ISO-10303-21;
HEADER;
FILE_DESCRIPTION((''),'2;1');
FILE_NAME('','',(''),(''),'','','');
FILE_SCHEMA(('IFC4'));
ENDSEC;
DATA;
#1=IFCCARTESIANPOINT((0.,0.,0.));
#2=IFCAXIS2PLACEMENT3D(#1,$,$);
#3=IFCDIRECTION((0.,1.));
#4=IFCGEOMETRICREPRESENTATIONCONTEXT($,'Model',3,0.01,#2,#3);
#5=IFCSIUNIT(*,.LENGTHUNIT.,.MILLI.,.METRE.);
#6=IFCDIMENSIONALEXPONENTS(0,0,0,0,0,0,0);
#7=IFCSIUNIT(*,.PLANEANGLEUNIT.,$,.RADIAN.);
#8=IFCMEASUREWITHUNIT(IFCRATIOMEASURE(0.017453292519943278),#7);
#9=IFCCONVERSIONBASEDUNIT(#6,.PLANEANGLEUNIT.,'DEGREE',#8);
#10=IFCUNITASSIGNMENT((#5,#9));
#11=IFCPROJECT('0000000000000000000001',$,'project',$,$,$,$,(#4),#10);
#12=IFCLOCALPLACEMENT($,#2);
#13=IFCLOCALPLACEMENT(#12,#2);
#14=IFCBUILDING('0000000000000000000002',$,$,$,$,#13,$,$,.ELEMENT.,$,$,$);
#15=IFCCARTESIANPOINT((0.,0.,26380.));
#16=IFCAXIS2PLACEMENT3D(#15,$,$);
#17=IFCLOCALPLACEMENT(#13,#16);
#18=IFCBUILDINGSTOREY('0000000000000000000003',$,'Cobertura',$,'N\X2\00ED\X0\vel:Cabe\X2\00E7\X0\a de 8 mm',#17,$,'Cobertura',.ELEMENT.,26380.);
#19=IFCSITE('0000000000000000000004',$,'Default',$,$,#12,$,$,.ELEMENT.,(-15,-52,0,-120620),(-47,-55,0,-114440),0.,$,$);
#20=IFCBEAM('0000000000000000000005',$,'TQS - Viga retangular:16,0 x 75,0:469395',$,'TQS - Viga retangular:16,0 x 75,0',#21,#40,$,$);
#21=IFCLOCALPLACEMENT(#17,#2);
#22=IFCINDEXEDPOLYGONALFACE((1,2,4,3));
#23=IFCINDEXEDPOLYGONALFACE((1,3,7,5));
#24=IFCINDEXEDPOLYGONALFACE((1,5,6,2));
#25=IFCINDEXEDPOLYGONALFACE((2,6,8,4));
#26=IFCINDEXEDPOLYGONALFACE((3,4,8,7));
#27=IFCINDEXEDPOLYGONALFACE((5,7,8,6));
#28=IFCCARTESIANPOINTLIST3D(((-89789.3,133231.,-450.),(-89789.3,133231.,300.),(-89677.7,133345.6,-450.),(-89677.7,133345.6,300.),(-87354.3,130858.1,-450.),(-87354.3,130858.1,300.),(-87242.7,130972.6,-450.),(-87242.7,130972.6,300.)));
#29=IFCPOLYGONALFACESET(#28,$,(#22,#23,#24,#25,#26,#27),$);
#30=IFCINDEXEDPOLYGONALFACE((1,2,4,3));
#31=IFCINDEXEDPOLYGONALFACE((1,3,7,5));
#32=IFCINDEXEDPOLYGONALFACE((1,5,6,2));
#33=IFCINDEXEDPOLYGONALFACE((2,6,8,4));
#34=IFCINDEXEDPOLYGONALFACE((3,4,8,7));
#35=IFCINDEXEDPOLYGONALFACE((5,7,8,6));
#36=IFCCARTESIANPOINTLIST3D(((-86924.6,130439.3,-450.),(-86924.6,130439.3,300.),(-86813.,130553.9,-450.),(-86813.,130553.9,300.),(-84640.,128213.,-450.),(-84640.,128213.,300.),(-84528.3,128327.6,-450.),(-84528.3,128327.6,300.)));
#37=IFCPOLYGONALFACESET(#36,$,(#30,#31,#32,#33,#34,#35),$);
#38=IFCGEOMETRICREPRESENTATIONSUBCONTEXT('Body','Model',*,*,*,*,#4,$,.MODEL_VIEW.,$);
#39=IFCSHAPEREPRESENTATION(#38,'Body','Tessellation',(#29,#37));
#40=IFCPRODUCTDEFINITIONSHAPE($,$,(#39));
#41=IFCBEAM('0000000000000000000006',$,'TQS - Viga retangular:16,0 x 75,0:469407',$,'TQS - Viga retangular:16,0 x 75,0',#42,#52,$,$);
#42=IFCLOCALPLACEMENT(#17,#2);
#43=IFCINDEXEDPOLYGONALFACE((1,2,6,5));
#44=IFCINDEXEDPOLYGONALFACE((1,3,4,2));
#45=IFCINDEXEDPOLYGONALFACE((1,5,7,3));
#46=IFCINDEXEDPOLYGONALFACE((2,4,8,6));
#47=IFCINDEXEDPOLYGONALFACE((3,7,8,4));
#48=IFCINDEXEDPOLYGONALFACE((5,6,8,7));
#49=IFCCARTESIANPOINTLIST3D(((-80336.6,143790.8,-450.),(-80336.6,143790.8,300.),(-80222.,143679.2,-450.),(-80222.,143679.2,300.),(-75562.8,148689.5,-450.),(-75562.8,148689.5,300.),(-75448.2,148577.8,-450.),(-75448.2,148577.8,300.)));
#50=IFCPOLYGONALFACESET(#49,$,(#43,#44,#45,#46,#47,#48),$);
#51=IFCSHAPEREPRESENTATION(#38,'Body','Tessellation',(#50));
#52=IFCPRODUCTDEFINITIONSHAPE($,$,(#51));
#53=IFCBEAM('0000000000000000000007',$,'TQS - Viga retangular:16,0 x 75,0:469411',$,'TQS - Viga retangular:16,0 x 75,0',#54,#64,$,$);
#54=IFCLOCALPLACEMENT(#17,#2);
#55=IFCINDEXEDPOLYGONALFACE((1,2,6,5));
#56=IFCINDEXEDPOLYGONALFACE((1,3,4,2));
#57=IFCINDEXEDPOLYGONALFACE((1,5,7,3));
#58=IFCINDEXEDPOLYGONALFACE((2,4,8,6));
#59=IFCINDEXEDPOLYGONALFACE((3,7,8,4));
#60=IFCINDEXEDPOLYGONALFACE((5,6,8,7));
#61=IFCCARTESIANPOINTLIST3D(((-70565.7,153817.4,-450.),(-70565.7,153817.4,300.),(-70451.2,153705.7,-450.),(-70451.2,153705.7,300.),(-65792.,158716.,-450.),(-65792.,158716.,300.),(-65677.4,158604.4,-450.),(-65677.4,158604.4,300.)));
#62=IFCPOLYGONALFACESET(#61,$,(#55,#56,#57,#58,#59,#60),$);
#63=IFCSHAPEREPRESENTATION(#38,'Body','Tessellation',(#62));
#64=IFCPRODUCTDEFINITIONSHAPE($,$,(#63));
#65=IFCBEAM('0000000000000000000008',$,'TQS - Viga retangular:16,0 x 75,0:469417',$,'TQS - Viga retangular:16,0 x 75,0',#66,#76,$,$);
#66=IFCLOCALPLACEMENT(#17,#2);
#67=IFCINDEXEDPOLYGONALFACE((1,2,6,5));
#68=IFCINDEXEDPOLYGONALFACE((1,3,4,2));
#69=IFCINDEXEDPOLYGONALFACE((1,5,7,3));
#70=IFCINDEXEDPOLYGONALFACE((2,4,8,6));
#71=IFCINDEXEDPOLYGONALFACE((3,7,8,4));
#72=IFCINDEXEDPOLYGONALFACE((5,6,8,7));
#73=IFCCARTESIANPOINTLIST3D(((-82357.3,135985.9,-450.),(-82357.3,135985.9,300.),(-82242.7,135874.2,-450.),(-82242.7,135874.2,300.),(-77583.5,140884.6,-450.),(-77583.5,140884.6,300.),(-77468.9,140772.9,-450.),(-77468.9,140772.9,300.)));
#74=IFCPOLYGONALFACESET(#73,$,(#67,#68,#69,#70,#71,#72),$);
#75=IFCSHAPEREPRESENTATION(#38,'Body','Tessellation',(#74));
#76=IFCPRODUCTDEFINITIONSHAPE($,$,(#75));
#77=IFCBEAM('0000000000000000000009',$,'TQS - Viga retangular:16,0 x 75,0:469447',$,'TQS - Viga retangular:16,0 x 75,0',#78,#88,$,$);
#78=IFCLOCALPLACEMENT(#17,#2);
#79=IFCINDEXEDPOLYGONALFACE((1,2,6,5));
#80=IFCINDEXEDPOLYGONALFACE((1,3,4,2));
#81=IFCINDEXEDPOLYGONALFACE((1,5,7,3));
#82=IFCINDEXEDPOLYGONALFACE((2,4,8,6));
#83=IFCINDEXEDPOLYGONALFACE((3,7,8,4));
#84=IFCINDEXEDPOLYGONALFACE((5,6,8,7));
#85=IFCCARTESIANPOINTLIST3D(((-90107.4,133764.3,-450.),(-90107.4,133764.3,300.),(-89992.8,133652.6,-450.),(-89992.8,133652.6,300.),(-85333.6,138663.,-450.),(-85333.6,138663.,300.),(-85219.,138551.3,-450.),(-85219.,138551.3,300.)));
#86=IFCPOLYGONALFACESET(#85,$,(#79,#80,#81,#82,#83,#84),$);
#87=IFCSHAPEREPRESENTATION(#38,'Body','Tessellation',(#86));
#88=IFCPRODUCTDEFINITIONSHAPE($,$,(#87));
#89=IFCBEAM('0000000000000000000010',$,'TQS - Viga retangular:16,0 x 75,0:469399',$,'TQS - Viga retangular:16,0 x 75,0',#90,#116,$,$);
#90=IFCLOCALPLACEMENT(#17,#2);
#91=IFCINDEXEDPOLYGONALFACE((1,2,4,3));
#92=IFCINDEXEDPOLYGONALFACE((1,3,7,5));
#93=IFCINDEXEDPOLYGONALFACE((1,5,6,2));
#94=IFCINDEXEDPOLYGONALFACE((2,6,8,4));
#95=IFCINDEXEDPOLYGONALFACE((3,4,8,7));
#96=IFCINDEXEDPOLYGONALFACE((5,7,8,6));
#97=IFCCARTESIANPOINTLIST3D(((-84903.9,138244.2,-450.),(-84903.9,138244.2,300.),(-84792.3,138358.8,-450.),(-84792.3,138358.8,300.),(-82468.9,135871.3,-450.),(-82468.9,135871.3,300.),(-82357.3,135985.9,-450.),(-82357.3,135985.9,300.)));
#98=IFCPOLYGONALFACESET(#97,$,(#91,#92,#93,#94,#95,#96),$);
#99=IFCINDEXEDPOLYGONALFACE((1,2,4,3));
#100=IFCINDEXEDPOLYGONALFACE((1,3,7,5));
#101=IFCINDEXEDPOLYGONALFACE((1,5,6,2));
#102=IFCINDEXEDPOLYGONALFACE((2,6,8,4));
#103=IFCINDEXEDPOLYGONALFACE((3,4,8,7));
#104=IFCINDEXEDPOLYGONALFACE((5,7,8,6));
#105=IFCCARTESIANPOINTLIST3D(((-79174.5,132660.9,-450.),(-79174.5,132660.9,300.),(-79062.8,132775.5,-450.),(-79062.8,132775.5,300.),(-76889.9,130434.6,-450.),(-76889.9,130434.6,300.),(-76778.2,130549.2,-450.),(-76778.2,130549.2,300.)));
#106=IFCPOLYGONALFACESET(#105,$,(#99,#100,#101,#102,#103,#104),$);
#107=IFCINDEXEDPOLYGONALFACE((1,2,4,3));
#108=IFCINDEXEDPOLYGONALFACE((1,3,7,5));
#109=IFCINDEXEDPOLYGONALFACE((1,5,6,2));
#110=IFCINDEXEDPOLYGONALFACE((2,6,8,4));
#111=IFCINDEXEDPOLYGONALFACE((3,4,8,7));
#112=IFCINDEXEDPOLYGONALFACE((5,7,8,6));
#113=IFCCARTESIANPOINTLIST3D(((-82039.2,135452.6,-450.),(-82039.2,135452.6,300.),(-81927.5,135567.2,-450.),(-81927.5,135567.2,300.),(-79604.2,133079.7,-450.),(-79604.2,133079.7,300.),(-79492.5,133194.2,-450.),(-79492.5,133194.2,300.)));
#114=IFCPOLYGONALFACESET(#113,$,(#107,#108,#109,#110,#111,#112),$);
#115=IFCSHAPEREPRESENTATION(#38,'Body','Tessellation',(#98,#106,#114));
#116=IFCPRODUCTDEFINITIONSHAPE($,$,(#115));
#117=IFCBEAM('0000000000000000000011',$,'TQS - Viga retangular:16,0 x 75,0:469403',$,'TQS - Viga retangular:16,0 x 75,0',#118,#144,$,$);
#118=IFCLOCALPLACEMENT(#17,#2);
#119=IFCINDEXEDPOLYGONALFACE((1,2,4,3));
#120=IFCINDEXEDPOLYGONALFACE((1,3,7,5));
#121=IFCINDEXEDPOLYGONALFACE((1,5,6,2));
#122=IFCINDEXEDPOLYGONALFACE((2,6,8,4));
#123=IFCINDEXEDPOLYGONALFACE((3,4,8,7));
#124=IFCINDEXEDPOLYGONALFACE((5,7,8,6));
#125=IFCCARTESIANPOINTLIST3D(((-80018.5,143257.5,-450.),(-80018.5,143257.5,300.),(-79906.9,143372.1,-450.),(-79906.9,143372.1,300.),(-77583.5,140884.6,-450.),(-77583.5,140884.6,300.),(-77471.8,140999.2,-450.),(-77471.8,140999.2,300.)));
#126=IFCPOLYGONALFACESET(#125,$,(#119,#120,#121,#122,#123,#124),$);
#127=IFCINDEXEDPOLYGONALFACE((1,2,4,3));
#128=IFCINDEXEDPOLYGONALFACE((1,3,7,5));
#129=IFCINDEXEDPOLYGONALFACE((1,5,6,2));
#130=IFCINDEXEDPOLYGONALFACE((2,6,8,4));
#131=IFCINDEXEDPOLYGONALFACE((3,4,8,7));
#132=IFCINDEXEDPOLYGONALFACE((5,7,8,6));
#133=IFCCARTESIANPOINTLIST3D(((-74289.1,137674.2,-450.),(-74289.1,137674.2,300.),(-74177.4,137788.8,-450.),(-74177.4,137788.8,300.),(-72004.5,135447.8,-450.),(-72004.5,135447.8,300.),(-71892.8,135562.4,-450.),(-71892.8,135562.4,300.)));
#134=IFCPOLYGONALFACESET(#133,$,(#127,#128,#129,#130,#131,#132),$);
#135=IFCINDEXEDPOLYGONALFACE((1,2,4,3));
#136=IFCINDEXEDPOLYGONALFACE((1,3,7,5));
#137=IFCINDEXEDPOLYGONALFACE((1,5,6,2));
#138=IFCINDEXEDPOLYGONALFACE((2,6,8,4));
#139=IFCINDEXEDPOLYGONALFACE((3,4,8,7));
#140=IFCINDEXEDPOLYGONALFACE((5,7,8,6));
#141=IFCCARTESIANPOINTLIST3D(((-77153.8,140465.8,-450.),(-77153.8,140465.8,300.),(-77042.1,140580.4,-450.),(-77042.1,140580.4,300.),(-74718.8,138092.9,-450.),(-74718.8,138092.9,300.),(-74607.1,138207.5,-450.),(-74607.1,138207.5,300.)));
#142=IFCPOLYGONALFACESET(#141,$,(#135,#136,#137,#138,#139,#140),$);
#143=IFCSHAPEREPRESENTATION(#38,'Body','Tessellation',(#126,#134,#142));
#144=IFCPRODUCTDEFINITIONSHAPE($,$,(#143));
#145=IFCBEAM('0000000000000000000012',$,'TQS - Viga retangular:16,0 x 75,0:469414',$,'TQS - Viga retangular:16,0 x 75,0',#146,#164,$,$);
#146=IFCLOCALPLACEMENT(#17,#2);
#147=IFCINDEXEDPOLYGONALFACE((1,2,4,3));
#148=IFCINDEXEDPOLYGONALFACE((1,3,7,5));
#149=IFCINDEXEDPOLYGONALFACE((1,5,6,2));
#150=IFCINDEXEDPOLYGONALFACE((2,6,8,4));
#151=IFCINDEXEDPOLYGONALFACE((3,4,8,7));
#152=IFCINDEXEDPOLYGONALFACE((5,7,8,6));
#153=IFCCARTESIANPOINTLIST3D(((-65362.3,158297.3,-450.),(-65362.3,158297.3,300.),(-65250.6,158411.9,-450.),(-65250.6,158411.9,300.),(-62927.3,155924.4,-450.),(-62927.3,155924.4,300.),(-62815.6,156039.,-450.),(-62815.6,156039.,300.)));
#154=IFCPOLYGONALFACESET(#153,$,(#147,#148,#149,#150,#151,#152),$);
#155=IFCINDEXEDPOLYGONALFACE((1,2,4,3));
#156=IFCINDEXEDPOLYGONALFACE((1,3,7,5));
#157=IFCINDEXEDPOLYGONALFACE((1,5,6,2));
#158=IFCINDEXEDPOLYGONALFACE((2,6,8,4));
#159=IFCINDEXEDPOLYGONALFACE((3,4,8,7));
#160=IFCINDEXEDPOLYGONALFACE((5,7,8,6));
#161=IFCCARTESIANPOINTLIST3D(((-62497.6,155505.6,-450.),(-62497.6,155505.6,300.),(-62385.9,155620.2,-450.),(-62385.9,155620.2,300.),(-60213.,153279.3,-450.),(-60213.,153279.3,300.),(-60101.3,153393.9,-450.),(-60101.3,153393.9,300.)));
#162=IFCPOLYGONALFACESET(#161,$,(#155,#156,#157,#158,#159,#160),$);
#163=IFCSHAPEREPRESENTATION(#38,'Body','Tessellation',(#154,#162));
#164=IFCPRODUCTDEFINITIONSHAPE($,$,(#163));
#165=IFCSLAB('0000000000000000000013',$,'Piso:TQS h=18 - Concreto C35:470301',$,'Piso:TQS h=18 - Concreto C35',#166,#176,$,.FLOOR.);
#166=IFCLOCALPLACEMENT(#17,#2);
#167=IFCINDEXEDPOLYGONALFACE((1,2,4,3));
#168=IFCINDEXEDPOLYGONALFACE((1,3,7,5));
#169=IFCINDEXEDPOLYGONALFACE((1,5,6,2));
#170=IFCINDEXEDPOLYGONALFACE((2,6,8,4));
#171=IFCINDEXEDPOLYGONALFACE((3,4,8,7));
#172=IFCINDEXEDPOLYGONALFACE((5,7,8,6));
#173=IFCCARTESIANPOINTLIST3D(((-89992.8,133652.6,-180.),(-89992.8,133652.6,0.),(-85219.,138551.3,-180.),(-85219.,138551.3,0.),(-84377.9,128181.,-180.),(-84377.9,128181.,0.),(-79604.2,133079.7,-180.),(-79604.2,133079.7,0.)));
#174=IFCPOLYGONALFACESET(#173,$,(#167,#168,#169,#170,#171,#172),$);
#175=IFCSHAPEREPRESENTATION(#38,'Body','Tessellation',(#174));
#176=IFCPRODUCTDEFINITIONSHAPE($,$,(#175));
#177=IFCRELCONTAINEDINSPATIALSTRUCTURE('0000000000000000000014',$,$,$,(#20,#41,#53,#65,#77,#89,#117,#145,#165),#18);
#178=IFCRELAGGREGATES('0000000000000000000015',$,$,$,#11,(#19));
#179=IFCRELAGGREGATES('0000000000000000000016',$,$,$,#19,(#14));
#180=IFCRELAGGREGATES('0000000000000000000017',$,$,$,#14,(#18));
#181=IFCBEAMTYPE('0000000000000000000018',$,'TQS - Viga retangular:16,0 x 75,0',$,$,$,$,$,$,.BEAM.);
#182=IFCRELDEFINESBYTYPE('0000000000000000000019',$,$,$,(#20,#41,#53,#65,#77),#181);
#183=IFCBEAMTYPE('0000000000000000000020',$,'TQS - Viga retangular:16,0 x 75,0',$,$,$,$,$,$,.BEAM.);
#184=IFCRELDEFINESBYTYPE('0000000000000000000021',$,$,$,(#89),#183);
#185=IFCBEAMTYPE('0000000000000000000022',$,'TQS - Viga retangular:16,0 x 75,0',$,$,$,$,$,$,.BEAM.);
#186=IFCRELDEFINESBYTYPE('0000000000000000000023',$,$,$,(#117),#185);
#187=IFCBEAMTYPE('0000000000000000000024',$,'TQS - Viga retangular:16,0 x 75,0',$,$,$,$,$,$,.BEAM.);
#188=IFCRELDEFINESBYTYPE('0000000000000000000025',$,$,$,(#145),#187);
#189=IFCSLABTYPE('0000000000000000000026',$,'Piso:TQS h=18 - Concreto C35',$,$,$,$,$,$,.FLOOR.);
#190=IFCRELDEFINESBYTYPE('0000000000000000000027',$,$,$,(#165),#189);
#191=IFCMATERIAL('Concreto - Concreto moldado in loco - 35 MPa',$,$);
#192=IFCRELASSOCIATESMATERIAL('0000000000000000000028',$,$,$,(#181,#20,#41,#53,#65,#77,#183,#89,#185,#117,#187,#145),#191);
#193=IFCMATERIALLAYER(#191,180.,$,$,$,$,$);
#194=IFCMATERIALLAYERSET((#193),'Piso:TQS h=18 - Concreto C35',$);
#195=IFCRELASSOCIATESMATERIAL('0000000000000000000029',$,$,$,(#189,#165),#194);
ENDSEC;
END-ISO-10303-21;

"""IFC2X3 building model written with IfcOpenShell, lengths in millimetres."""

from ifc_helpers import new_model, entity, si_unit, converted_unit, direction, frame, frame_2d, origin, place, context, subcontext, project, spatial, rectangle, extrude, source, transform, mapped, material, layer, layer_set, layer_usage, type_object, type_shapes, element, save


model = new_model("IFC2X3")

# Units and contexts
model_context = context("Model", 3, precision=0.01, world=origin(), true_north=direction((0.0, 1.0)))
body_context = subcontext(model_context, "Body", "Model", "MODEL_VIEW")
ifc_project = project(units=[si_unit("LENGTHUNIT", "METRE", prefix="MILLI"), converted_unit("PLANEANGLEUNIT", "DEGREE", entity("IfcRatioMeasure", 0.017453292519943278), si_unit("PLANEANGLEUNIT", "RADIAN"), dimensions=[0, 0, 0, 0, 0, 0, 0])], contexts=[model_context])

# Site, building, storey
site_placement = place(None, origin())
site = spatial("IfcSite", under=ifc_project, at=site_placement, Name="Default", CompositionType="ELEMENT", RefLatitude=(-15, -52, 0, -120620), RefLongitude=(-47, -55, 0, -114440), RefElevation=0.0)
building_placement = place(site_placement, origin())
building = spatial("IfcBuilding", under=site, at=building_placement, CompositionType="ELEMENT")
storey_placement = place(building_placement, frame((0.0, 0.0, 26380.0)))
storey = spatial("IfcBuildingStorey", under=building, at=storey_placement, Name="Cobertura", ObjectType="Nível:Cabeça de 8 mm", LongName="Cobertura", CompositionType="ELEMENT", Elevation=26380.0)

# Beams
ifc_material = material(Name="Concreto - Concreto moldado in loco - 35 MPa")
beam_type_1 = type_object("IfcBeamType", Name="TQS - Viga retangular:16,0 x 75,0", PredefinedType="BEAM", material=ifc_material)
shared_shape_1 = source(origin(), body_context, "Body", "SweptSolid", [
    extrude(rectangle(XDim=750.0, YDim=160.0, at=frame_2d((0.0, 0.0), x_axis=(1.0, 0.0))), frame((-87298.5, 130915.4, 26305.0), z_axis=(-0.71618, 0.697915, 0.0), x_axis=(0.0, 0.0, 1.0)), (0.0, 0.0, 1.0), 3400.0),
    extrude(rectangle(XDim=750.0, YDim=160.0, at=frame_2d((0.0, 0.0), x_axis=(1.0, 0.0))), frame((-84584.2, 128270.3, 26305.0), z_axis=(-0.71618, 0.697915, 0.0), x_axis=(0.0, 0.0, 1.0)), (0.0, 0.0, 1.0), 3190.0),
])
type_shapes(beam_type_1, [shared_shape_1])
beam_1_placement = place(storey_placement, frame((0.0, 0.0, -26380.0)))
element("IfcBeam", 1, at=beam_1_placement, inside=storey, type_object=beam_type_1, material=ifc_material, Name="TQS - Viga retangular:16,0 x 75,0:469395", ObjectType="TQS - Viga retangular:16,0 x 75,0", context=body_context, shape_type="MappedRepresentation", body=[
    mapped(shared_shape_1, transform((0.0, 0.0, 0.0), scale=1.0)),
])
beam_2_placement = place(storey_placement, frame((-80335.1, 143677.7, 300.0), z_axis=(0.0, 0.0, 1.0), x_axis=(0.697915, 0.71618, 0.0)))
element("IfcBeam", 2, at=beam_2_placement, inside=storey, type_object=beam_type_1, material=ifc_material, Name="TQS - Viga retangular:16,0 x 75,0:469407", ObjectType="TQS - Viga retangular:16,0 x 75,0", context=body_context, shape_type="SweptSolid", body=[
    extrude(rectangle(XDim=750.0, YDim=160.0, at=frame_2d((0.0, 0.0), x_axis=(1.0, 0.0))), frame((80.0, 0.0, -375.0), z_axis=(1.0, 0.0, 0.0), x_axis=(0.0, 0.0, -1.0)), (0.0, 0.0, 1.0), 6840.0),
])
beam_3_placement = place(storey_placement, frame((-70564.3, 153704.2, 300.0), z_axis=(0.0, 0.0, 1.0), x_axis=(0.697915, 0.71618, 0.0)))
element("IfcBeam", 3, at=beam_3_placement, inside=storey, type_object=beam_type_1, material=ifc_material, Name="TQS - Viga retangular:16,0 x 75,0:469411", ObjectType="TQS - Viga retangular:16,0 x 75,0", context=body_context, shape_type="SweptSolid", body=[
    extrude(rectangle(XDim=750.0, YDim=160.0, at=frame_2d((0.0, 0.0), x_axis=(1.0, 0.0))), frame((80.0, 0.0, -375.0), z_axis=(1.0, 0.0, 0.0), x_axis=(0.0, 0.0, -1.0)), (0.0, 0.0, 1.0), 6840.0),
])
beam_4_placement = place(storey_placement, frame((-82355.8, 135872.8, 300.0), z_axis=(0.0, 0.0, 1.0), x_axis=(0.697915, 0.71618, 0.0)))
element("IfcBeam", 4, at=beam_4_placement, inside=storey, type_object=beam_type_1, material=ifc_material, Name="TQS - Viga retangular:16,0 x 75,0:469417", ObjectType="TQS - Viga retangular:16,0 x 75,0", context=body_context, shape_type="SweptSolid", body=[
    extrude(rectangle(XDim=750.0, YDim=160.0, at=frame_2d((0.0, 0.0), x_axis=(1.0, 0.0))), frame((80.0, 0.0, -375.0), z_axis=(1.0, 0.0, 0.0), x_axis=(0.0, 0.0, -1.0)), (0.0, 0.0, 1.0), 6840.0),
])
beam_5_placement = place(storey_placement, frame((-90105.9, 133651.2, 300.0), z_axis=(0.0, 0.0, 1.0), x_axis=(0.697915, 0.71618, 0.0)))
element("IfcBeam", 5, at=beam_5_placement, inside=storey, type_object=beam_type_1, material=ifc_material, Name="TQS - Viga retangular:16,0 x 75,0:469447", ObjectType="TQS - Viga retangular:16,0 x 75,0", context=body_context, shape_type="SweptSolid", body=[
    extrude(rectangle(XDim=750.0, YDim=160.0, at=frame_2d((0.0, 0.0), x_axis=(1.0, 0.0))), frame((80.0, 0.0, -375.0), z_axis=(1.0, 0.0, 0.0), x_axis=(0.0, 0.0, -1.0)), (0.0, 0.0, 1.0), 6840.0),
])
beam_type_2 = type_object("IfcBeamType", Name="TQS - Viga retangular:16,0 x 75,0", PredefinedType="BEAM", material=ifc_material)
shared_shape_2 = source(origin(), body_context, "Body", "SweptSolid", [
    extrude(rectangle(XDim=750.0, YDim=160.0, at=frame_2d((0.0, 0.0), x_axis=(1.0, 0.0))), frame((-82413.1, 135928.6, 26305.0), z_axis=(-0.71618, 0.697915, 0.0), x_axis=(0.0, 0.0, 1.0)), (0.0, 0.0, 1.0), 3400.0),
    extrude(rectangle(XDim=750.0, YDim=160.0, at=frame_2d((0.0, 0.0), x_axis=(1.0, 0.0))), frame((-76834.0, 130491.9, 26305.0), z_axis=(-0.71618, 0.697915, 0.0), x_axis=(0.0, 0.0, 1.0)), (0.0, 0.0, 1.0), 3190.0),
    extrude(rectangle(XDim=750.0, YDim=160.0, at=frame_2d((0.0, 0.0), x_axis=(1.0, 0.0))), frame((-79548.4, 133137.0, 26305.0), z_axis=(-0.71618, 0.697915, 0.0), x_axis=(0.0, 0.0, 1.0)), (0.0, 0.0, 1.0), 3400.0),
])
type_shapes(beam_type_2, [shared_shape_2])
beam_6_placement = place(storey_placement, frame((0.0, 0.0, -26380.0)))
element("IfcBeam", 6, at=beam_6_placement, inside=storey, type_object=beam_type_2, material=ifc_material, Name="TQS - Viga retangular:16,0 x 75,0:469399", ObjectType="TQS - Viga retangular:16,0 x 75,0", context=body_context, shape_type="MappedRepresentation", body=[
    mapped(shared_shape_2, transform((0.0, 0.0, 0.0), scale=1.0)),
])
beam_type_3 = type_object("IfcBeamType", Name="TQS - Viga retangular:16,0 x 75,0", PredefinedType="BEAM", material=ifc_material)
shared_shape_3 = source(origin(), body_context, "Body", "SweptSolid", [
    extrude(rectangle(XDim=750.0, YDim=160.0, at=frame_2d((0.0, 0.0), x_axis=(1.0, 0.0))), frame((-77527.7, 140941.9, 26305.0), z_axis=(-0.71618, 0.697915, 0.0), x_axis=(0.0, 0.0, 1.0)), (0.0, 0.0, 1.0), 3400.0),
    extrude(rectangle(XDim=750.0, YDim=160.0, at=frame_2d((0.0, 0.0), x_axis=(1.0, 0.0))), frame((-71948.6, 135505.1, 26305.0), z_axis=(-0.71618, 0.697915, 0.0), x_axis=(0.0, 0.0, 1.0)), (0.0, 0.0, 1.0), 3190.0),
    extrude(rectangle(XDim=750.0, YDim=160.0, at=frame_2d((0.0, 0.0), x_axis=(1.0, 0.0))), frame((-74663.0, 138150.2, 26305.0), z_axis=(-0.71618, 0.697915, 0.0), x_axis=(0.0, 0.0, 1.0)), (0.0, 0.0, 1.0), 3400.0),
])
type_shapes(beam_type_3, [shared_shape_3])
beam_7_placement = place(storey_placement, frame((0.0, 0.0, -26380.0)))
element("IfcBeam", 7, at=beam_7_placement, inside=storey, type_object=beam_type_3, material=ifc_material, Name="TQS - Viga retangular:16,0 x 75,0:469403", ObjectType="TQS - Viga retangular:16,0 x 75,0", context=body_context, shape_type="MappedRepresentation", body=[
    mapped(shared_shape_3, transform((0.0, 0.0, 0.0), scale=1.0)),
])
beam_type_4 = type_object("IfcBeamType", Name="TQS - Viga retangular:16,0 x 75,0", PredefinedType="BEAM", material=ifc_material)
shared_shape_4 = source(origin(), body_context, "Body", "SweptSolid", [
    extrude(rectangle(XDim=750.0, YDim=160.0, at=frame_2d((0.0, 0.0), x_axis=(1.0, 0.0))), frame((-62871.5, 155981.7, 26305.0), z_axis=(-0.71618, 0.697915, 0.0), x_axis=(0.0, 0.0, 1.0)), (0.0, 0.0, 1.0), 3400.0),
    extrude(rectangle(XDim=750.0, YDim=160.0, at=frame_2d((0.0, 0.0), x_axis=(1.0, 0.0))), frame((-60157.1, 153336.6, 26305.0), z_axis=(-0.71618, 0.697915, 0.0), x_axis=(0.0, 0.0, 1.0)), (0.0, 0.0, 1.0), 3190.0),
])
type_shapes(beam_type_4, [shared_shape_4])
beam_8_placement = place(storey_placement, frame((0.0, 0.0, -26380.0)))
element("IfcBeam", 8, at=beam_8_placement, inside=storey, type_object=beam_type_4, material=ifc_material, Name="TQS - Viga retangular:16,0 x 75,0:469414", ObjectType="TQS - Viga retangular:16,0 x 75,0", context=body_context, shape_type="MappedRepresentation", body=[
    mapped(shared_shape_4, transform((0.0, 0.0, 0.0), scale=1.0)),
])

# Slab
ifc_layer_1 = layer(ifc_material, 180.0)
ifc_layer_set_1 = layer_set([ifc_layer_1], Name="Piso:TQS h=18 - Concreto C35")
ifc_layer_usage_1 = layer_usage(ifc_layer_set_1, "AXIS3", "POSITIVE", 0.0)
slab_type_1 = type_object("IfcSlabType", Name="Piso:TQS h=18 - Concreto C35", PredefinedType="FLOOR", material=ifc_layer_set_1)
slab_1_placement = place(storey_placement, origin())
element("IfcSlab", 9, at=slab_1_placement, inside=storey, type_object=slab_type_1, material=ifc_layer_usage_1, Name="Piso:TQS h=18 - Concreto C35:470301", ObjectType="Piso:TQS h=18 - Concreto C35", PredefinedType="FLOOR", context=body_context, shape_type="SweptSolid", body=[
    extrude(rectangle(XDim=6840.0, YDim=7840.0, at=frame_2d((0.0, 0.0), x_axis=(1.0, 0.0))), frame((-84798.5, 133366.2, 0.0), z_axis=(0.0, 0.0, -1.0), x_axis=(-0.697915, -0.71618, 0.0)), (0.0, 0.0, 1.0), 180.0),
])

save(model, "model.ifc")
